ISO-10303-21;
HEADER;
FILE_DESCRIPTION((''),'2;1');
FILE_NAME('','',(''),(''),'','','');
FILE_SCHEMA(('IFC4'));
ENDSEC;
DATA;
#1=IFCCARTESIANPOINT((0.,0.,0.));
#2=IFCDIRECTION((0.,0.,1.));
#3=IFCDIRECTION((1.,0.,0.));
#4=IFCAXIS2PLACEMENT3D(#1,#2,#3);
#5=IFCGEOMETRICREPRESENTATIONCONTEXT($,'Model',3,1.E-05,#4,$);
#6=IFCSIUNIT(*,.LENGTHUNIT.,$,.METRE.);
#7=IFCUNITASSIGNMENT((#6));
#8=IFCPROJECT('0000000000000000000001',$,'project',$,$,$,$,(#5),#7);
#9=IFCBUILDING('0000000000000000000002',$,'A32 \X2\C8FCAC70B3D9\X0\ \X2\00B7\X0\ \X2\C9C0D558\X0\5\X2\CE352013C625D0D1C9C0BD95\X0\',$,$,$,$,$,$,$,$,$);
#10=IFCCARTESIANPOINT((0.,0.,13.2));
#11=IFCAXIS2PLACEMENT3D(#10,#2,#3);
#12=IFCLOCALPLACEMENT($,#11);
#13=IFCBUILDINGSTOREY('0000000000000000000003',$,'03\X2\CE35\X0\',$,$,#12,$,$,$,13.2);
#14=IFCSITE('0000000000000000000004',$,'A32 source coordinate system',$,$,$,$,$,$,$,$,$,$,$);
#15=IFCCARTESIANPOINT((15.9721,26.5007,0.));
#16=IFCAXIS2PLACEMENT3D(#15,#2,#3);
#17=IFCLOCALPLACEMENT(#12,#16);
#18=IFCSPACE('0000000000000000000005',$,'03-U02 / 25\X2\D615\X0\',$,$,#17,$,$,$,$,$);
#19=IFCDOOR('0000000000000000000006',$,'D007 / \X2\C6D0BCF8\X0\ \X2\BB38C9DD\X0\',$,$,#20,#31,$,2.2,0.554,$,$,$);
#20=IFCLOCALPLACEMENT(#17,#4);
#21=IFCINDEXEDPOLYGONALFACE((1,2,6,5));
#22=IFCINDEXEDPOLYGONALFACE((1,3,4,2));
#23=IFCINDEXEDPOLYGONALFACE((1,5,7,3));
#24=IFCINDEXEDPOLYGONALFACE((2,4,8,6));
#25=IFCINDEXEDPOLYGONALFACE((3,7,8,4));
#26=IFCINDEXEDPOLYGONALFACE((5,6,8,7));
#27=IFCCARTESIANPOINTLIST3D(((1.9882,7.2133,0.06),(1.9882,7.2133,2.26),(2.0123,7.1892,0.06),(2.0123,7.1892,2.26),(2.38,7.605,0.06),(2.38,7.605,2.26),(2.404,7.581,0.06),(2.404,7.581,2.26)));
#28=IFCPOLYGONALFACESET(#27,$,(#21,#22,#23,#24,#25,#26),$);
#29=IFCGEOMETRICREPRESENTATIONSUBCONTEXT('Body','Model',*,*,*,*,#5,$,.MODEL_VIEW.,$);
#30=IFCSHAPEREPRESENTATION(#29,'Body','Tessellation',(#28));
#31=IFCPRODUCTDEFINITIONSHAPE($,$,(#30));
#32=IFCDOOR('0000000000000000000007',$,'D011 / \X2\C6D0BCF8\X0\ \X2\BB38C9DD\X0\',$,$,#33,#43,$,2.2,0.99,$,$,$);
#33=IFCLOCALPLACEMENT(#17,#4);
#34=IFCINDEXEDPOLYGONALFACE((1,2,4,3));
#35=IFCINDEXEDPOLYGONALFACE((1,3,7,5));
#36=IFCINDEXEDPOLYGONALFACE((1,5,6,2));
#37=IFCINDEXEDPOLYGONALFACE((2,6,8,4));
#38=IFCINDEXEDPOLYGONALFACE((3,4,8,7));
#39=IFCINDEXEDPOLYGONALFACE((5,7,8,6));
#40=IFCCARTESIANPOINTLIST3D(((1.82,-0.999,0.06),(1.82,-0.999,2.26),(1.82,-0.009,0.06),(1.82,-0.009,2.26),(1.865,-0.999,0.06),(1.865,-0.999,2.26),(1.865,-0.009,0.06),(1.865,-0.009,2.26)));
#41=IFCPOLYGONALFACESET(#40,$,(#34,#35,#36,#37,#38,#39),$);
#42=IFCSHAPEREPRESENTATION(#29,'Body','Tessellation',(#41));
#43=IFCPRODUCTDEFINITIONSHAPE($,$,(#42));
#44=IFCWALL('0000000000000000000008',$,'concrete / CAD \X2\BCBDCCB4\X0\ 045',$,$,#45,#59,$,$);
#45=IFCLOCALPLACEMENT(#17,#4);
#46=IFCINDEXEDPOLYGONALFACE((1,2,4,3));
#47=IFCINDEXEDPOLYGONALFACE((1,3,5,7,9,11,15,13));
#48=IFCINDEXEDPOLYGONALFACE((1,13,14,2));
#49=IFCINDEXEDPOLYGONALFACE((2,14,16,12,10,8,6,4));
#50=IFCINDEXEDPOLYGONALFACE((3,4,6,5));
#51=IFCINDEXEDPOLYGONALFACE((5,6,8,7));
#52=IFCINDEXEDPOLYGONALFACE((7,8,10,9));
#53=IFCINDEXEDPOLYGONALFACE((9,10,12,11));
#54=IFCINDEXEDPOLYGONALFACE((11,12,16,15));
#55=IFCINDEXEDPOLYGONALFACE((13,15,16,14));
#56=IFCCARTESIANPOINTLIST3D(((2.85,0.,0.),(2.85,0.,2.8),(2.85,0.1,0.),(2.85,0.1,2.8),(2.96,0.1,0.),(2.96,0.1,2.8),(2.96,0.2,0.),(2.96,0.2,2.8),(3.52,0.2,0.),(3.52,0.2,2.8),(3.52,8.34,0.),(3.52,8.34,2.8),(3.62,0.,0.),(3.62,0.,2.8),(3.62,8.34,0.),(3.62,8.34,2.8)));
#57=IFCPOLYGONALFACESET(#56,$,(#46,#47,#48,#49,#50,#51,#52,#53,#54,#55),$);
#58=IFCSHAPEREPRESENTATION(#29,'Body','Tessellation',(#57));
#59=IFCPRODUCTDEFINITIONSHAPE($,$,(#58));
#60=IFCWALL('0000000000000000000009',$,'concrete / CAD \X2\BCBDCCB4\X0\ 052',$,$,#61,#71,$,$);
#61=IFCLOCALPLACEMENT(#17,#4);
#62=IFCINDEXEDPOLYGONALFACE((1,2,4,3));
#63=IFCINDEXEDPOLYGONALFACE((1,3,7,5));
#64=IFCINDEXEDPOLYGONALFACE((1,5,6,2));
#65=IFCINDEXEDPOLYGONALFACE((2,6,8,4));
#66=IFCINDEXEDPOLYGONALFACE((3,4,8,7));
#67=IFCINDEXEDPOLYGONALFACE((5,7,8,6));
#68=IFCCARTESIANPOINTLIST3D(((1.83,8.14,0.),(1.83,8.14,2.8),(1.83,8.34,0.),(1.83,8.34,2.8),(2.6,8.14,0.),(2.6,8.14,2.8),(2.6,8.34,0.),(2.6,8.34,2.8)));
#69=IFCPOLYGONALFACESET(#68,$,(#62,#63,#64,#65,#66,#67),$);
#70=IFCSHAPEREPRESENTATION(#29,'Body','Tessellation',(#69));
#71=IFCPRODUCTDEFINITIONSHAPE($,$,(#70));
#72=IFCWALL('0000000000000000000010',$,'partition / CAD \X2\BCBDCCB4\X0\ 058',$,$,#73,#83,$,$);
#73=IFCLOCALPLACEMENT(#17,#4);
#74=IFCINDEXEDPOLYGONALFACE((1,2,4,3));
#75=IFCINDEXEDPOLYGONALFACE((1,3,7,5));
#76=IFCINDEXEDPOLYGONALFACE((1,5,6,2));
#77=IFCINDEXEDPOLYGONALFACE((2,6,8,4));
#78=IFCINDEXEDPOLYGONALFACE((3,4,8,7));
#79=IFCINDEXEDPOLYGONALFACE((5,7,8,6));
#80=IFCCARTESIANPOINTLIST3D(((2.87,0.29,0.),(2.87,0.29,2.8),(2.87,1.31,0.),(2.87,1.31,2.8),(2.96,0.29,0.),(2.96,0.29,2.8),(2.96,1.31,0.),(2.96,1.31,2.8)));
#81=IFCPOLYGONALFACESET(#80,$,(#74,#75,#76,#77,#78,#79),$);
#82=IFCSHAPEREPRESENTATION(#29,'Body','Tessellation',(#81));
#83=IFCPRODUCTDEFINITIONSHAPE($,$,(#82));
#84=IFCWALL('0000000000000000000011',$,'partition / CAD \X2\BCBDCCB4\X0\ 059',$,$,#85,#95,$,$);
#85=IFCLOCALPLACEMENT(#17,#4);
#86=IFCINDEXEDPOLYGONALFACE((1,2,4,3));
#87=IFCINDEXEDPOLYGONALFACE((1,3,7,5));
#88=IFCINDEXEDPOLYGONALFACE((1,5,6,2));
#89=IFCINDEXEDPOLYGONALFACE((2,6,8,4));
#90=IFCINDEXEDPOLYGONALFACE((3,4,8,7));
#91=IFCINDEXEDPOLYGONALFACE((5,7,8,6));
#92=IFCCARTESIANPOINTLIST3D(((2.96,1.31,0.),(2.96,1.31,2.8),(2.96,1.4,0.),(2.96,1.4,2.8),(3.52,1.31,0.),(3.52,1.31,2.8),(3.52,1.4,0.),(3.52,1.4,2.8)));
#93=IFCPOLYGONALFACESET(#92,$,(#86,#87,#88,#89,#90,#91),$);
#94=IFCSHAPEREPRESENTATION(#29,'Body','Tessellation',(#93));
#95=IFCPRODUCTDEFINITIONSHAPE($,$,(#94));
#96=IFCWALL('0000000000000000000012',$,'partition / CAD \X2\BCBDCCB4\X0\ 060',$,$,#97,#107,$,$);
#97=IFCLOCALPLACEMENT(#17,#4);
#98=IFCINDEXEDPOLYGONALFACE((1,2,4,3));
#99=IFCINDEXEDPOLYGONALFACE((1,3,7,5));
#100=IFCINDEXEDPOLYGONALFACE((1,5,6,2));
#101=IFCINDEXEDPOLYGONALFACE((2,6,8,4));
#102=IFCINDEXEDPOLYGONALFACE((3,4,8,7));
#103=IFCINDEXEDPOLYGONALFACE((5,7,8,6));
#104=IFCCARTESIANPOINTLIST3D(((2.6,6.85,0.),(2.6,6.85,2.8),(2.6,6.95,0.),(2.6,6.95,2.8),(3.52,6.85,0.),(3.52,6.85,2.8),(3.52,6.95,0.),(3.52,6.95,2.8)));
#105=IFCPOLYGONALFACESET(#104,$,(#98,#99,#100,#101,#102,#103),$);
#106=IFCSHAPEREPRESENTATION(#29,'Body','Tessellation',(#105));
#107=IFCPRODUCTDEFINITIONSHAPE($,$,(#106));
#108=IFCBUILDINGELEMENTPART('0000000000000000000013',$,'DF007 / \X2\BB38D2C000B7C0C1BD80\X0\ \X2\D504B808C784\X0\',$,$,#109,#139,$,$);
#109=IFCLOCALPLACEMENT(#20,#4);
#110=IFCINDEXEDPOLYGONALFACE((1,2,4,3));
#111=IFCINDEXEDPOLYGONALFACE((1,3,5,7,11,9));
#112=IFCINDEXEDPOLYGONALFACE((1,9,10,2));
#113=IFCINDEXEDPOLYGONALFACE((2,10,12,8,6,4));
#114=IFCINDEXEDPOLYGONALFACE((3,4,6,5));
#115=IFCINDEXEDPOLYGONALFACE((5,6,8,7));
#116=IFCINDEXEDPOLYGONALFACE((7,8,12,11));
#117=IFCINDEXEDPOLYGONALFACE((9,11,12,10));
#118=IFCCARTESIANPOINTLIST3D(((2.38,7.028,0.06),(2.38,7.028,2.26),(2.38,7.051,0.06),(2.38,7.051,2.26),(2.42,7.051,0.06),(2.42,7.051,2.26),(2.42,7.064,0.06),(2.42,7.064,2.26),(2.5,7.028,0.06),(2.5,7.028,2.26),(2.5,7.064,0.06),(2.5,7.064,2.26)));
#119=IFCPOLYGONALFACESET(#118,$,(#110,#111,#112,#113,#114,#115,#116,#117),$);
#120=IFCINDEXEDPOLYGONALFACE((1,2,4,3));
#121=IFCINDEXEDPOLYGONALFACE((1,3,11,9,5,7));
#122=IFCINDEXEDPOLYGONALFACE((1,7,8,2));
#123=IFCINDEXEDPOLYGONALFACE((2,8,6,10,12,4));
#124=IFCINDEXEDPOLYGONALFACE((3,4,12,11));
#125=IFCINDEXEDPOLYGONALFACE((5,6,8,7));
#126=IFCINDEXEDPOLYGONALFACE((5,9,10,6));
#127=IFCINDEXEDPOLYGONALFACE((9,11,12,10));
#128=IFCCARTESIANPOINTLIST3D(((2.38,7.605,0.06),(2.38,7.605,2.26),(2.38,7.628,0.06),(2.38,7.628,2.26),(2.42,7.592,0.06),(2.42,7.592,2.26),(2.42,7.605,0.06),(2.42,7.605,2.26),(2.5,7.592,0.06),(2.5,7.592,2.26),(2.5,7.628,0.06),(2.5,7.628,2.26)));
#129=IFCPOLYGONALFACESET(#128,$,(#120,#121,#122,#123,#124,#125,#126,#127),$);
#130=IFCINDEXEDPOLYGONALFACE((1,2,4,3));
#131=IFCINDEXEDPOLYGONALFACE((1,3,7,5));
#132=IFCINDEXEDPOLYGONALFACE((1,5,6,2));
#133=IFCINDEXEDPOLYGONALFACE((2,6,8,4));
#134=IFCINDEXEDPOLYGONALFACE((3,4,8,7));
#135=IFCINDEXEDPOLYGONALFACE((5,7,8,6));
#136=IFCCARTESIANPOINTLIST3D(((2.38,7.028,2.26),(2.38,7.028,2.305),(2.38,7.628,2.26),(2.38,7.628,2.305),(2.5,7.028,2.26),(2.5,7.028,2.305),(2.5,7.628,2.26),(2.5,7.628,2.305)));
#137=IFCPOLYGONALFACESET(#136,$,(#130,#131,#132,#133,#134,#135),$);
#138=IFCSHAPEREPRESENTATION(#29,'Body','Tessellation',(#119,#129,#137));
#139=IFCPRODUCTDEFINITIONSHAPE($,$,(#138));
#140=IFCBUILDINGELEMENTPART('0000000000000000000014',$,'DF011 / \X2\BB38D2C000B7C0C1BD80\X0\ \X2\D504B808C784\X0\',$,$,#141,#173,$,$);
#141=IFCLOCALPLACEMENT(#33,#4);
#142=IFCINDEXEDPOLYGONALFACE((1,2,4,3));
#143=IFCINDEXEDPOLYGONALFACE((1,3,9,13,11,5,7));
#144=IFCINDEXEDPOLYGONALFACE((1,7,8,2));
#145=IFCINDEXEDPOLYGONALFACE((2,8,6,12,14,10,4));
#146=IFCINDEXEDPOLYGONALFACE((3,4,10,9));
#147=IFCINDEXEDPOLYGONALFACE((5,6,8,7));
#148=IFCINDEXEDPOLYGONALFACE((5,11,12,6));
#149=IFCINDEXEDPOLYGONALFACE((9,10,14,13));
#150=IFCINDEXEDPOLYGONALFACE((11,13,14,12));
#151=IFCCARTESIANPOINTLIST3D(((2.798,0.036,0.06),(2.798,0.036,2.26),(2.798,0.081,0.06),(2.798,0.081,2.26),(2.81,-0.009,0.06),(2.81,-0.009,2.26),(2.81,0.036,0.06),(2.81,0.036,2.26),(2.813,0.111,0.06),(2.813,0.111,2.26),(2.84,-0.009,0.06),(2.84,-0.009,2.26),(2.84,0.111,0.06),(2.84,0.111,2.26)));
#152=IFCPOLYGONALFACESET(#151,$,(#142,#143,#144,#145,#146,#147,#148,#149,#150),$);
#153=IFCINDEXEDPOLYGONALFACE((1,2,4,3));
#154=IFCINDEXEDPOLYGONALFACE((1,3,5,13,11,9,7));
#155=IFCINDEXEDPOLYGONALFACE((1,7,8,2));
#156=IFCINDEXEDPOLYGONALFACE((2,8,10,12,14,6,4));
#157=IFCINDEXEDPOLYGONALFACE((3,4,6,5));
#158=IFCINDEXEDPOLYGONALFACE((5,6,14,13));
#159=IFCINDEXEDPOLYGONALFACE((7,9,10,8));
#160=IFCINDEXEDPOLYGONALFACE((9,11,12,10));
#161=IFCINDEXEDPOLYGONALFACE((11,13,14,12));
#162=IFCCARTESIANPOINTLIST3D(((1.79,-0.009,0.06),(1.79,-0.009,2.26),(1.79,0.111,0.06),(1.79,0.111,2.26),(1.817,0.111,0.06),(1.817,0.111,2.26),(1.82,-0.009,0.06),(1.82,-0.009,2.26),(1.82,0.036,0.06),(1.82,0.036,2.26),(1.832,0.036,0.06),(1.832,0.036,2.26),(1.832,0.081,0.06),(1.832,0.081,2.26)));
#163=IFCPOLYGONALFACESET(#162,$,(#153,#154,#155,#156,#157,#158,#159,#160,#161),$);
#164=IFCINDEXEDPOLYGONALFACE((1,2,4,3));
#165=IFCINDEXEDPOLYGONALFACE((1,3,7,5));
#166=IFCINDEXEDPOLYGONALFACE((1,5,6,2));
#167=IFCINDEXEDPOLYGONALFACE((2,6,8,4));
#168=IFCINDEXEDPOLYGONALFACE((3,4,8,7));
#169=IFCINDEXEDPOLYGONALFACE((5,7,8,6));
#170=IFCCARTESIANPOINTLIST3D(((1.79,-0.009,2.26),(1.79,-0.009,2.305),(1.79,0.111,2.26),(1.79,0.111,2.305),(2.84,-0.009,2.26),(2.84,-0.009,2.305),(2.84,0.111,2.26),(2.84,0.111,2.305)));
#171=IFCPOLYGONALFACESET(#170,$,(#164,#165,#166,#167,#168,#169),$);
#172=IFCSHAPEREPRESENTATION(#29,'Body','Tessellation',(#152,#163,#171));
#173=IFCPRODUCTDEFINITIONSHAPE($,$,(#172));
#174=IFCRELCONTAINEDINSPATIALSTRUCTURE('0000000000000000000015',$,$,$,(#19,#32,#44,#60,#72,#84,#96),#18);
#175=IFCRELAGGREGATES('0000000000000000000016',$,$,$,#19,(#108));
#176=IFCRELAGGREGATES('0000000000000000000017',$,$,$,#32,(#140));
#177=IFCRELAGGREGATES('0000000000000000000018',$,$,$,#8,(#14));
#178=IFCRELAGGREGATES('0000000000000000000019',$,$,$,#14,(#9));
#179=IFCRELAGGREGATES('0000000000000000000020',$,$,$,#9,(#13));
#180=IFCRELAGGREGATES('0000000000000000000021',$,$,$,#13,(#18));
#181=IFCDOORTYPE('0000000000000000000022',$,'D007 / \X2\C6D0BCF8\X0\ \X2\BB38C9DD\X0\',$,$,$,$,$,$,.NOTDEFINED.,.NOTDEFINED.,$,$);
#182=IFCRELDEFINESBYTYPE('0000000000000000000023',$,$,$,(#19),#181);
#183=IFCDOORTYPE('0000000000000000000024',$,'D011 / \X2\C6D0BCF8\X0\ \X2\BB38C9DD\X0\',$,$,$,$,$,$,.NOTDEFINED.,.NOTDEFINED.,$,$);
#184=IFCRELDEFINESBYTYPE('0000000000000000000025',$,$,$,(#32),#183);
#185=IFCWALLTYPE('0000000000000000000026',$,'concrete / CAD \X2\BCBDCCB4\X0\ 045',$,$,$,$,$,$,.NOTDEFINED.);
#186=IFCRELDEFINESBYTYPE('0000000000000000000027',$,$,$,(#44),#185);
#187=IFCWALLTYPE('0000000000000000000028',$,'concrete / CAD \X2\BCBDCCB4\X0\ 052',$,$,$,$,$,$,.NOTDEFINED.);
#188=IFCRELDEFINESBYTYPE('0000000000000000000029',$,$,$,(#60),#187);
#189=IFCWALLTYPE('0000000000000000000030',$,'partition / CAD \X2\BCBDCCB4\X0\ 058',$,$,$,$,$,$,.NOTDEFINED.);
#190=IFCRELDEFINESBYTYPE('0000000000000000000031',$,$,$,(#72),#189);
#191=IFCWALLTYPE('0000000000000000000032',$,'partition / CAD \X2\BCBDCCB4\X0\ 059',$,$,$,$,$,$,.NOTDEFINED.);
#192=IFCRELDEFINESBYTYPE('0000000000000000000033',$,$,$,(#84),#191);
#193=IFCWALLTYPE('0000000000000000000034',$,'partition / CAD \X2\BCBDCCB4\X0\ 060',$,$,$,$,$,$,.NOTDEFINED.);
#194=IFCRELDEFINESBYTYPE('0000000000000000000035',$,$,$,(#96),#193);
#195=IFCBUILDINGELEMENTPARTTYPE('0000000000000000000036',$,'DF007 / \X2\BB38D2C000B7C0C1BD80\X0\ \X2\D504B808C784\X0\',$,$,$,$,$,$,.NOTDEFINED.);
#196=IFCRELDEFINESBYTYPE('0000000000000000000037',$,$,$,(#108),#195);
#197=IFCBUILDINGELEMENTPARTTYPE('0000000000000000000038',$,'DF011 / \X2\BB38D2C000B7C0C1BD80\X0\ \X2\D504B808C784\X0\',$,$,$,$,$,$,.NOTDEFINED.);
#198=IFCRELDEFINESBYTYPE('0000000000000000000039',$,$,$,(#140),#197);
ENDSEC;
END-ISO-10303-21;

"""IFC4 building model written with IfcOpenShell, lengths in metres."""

from ifc_helpers import new_model, si_unit, frame, origin, origin_with_axes, place, context, subcontext, project, spatial, polyline, outline, extrude, source, transform, mapped, type_object, type_shapes, element, aggregate, save


model = new_model("IFC4")

# Units and contexts
model_context = context("Model", 3, precision=1e-05, world=origin_with_axes())
body_context = subcontext(model_context, "Body", "Model", "MODEL_VIEW")
ifc_project = project(units=[si_unit("LENGTHUNIT", "METRE")], contexts=[model_context])

# Site, building, storey, space
storey_placement = place(None, frame((0.0, 0.0, 13.2), z_axis=(0.0, 0.0, 1.0), x_axis=(1.0, 0.0, 0.0)))
space_placement = place(storey_placement, frame((15.9721, 26.5007, 0.0), z_axis=(0.0, 0.0, 1.0), x_axis=(1.0, 0.0, 0.0)))
site = spatial("IfcSite", under=ifc_project, Name="A32 source coordinate system")
building = spatial("IfcBuilding", under=site, Name="A32 주거동 · 지하5층–옥탑지붕")
storey = spatial("IfcBuildingStorey", under=building, at=storey_placement, Name="03층", Elevation=13.2)
space = spatial("IfcSpace", under=storey, at=space_placement, Name="03-U02 / 25형")

# Doors
door_type_1 = type_object("IfcDoorType", Name="D007 / 원본 문짝", OperationType="NOTDEFINED", PredefinedType="NOTDEFINED")
shared_shape_1 = source(origin(), body_context, "Body", "SweptSolid", [
    extrude(outline(polyline([(2.0123, 7.1892), (1.9882, 7.2133), (2.38, 7.605), (2.404, 7.581), (2.0123, 7.1892)])), frame((0.0, 0.0, 0.06)), (0.0, 0.0, 1.0), 2.2),
])
type_shapes(door_type_1, [shared_shape_1])
door_1_placement = place(space_placement, origin_with_axes())
door_1 = element("IfcDoor", 1, at=door_1_placement, inside=space, type_object=door_type_1, Name="D007 / 원본 문짝", OverallHeight=2.2, OverallWidth=0.554, context=body_context, shape_type="MappedRepresentation", body=[
    mapped(shared_shape_1, transform((0.0, 0.0, 0.0), scale=1.0)),
])
door_type_2 = type_object("IfcDoorType", Name="D011 / 원본 문짝", OperationType="NOTDEFINED", PredefinedType="NOTDEFINED")
shared_shape_2 = source(origin(), body_context, "Body", "SweptSolid", [
    extrude(outline(polyline([(1.865, -0.999), (1.82, -0.999), (1.82, -0.009), (1.865, -0.009), (1.865, -0.999)])), frame((0.0, 0.0, 0.06)), (0.0, 0.0, 1.0), 2.2),
])
type_shapes(door_type_2, [shared_shape_2])
door_2_placement = place(space_placement, origin_with_axes())
door_2 = element("IfcDoor", 2, at=door_2_placement, inside=space, type_object=door_type_2, Name="D011 / 원본 문짝", OverallHeight=2.2, OverallWidth=0.99, context=body_context, shape_type="MappedRepresentation", body=[
    mapped(shared_shape_2, transform((0.0, 0.0, 0.0), scale=1.0)),
])

# Walls
wall_type_1 = type_object("IfcWallType", Name="concrete / CAD 벽체 045", PredefinedType="NOTDEFINED")
shared_shape_3 = source(origin(), body_context, "Body", "SweptSolid", [
    extrude(outline(polyline([(2.96, 0.1), (2.96, 0.2), (3.52, 0.2), (3.52, 8.34), (3.72, 8.34), (3.72, 8.34), (3.62, 8.34), (3.62, 0.0), (2.85, 0.0), (2.85, 0.1), (2.96, 0.1)])), origin(), (0.0, 0.0, 1.0), 2.8),
])
type_shapes(wall_type_1, [shared_shape_3])
wall_1_placement = place(space_placement, origin_with_axes())
element("IfcWall", 3, at=wall_1_placement, inside=space, type_object=wall_type_1, Name="concrete / CAD 벽체 045", context=body_context, shape_type="MappedRepresentation", body=[
    mapped(shared_shape_3, transform((0.0, 0.0, 0.0), scale=1.0)),
])
wall_type_2 = type_object("IfcWallType", Name="concrete / CAD 벽체 052", PredefinedType="NOTDEFINED")
shared_shape_4 = source(origin(), body_context, "Body", "SweptSolid", [
    extrude(outline(polyline([(2.6, 8.14), (1.83, 8.14), (1.83, 8.34), (2.6, 8.34), (2.6, 8.14)])), origin(), (0.0, 0.0, 1.0), 2.8),
])
type_shapes(wall_type_2, [shared_shape_4])
wall_2_placement = place(space_placement, origin_with_axes())
element("IfcWall", 4, at=wall_2_placement, inside=space, type_object=wall_type_2, Name="concrete / CAD 벽체 052", context=body_context, shape_type="MappedRepresentation", body=[
    mapped(shared_shape_4, transform((0.0, 0.0, 0.0), scale=1.0)),
])
wall_type_3 = type_object("IfcWallType", Name="partition / CAD 벽체 058", PredefinedType="NOTDEFINED")
shared_shape_5 = source(origin(), body_context, "Body", "SweptSolid", [
    extrude(outline(polyline([(2.96, 1.31), (2.96, 0.29), (2.87, 0.29), (2.87, 1.31), (2.96, 1.31)])), origin(), (0.0, 0.0, 1.0), 2.8),
])
type_shapes(wall_type_3, [shared_shape_5])
wall_3_placement = place(space_placement, origin_with_axes())
element("IfcWall", 5, at=wall_3_placement, inside=space, type_object=wall_type_3, Name="partition / CAD 벽체 058", context=body_context, shape_type="MappedRepresentation", body=[
    mapped(shared_shape_5, transform((0.0, 0.0, 0.0), scale=1.0)),
])
wall_type_4 = type_object("IfcWallType", Name="partition / CAD 벽체 059", PredefinedType="NOTDEFINED")
shared_shape_6 = source(origin(), body_context, "Body", "SweptSolid", [
    extrude(outline(polyline([(3.52, 1.31), (2.96, 1.31), (2.96, 1.4), (3.52, 1.4), (3.52, 1.31)])), origin(), (0.0, 0.0, 1.0), 2.8),
])
type_shapes(wall_type_4, [shared_shape_6])
wall_4_placement = place(space_placement, origin_with_axes())
element("IfcWall", 6, at=wall_4_placement, inside=space, type_object=wall_type_4, Name="partition / CAD 벽체 059", context=body_context, shape_type="MappedRepresentation", body=[
    mapped(shared_shape_6, transform((0.0, 0.0, 0.0), scale=1.0)),
])
wall_type_5 = type_object("IfcWallType", Name="partition / CAD 벽체 060", PredefinedType="NOTDEFINED")
shared_shape_7 = source(origin(), body_context, "Body", "SweptSolid", [
    extrude(outline(polyline([(3.52, 6.85), (2.6, 6.85), (2.6, 6.95), (3.52, 6.95), (3.52, 6.85)])), origin(), (0.0, 0.0, 1.0), 2.8),
])
type_shapes(wall_type_5, [shared_shape_7])
wall_5_placement = place(space_placement, origin_with_axes())
element("IfcWall", 7, at=wall_5_placement, inside=space, type_object=wall_type_5, Name="partition / CAD 벽체 060", context=body_context, shape_type="MappedRepresentation", body=[
    mapped(shared_shape_7, transform((0.0, 0.0, 0.0), scale=1.0)),
])

# Building element parts
building_element_part_type_1 = type_object("IfcBuildingElementPartType", Name="DF007 / 문틀·상부 프레임", PredefinedType="NOTDEFINED")
shared_shape_8 = source(origin(), body_context, "Body", "SweptSolid", [
    extrude(outline(polyline([(2.38, 7.028), (2.38, 7.051), (2.42, 7.051), (2.42, 7.064), (2.5, 7.064), (2.5, 7.028), (2.38, 7.028)])), frame((0.0, 0.0, 0.06)), (0.0, 0.0, 1.0), 2.2),
    extrude(outline(polyline([(2.5, 7.592), (2.42, 7.592), (2.42, 7.605), (2.38, 7.605), (2.38, 7.628), (2.5, 7.628), (2.5, 7.592)])), frame((0.0, 0.0, 0.06)), (0.0, 0.0, 1.0), 2.2),
    extrude(outline(polyline([(2.38, 7.028), (2.38, 7.628), (2.5, 7.628), (2.5, 7.028), (2.38, 7.028)])), frame((0.0, 0.0, 2.26)), (0.0, 0.0, 1.0), 0.045),
])
type_shapes(building_element_part_type_1, [shared_shape_8])
building_element_part_1_placement = place(door_1_placement, origin_with_axes())
building_element_part_1 = element("IfcBuildingElementPart", 8, at=building_element_part_1_placement, type_object=building_element_part_type_1, Name="DF007 / 문틀·상부 프레임", context=body_context, shape_type="MappedRepresentation", body=[
    mapped(shared_shape_8, transform((0.0, 0.0, 0.0), scale=1.0)),
])
aggregate(door_1, [building_element_part_1])
building_element_part_type_2 = type_object("IfcBuildingElementPartType", Name="DF011 / 문틀·상부 프레임", PredefinedType="NOTDEFINED")
shared_shape_9 = source(origin(), body_context, "Body", "SweptSolid", [
    extrude(outline(polyline([(2.81, -0.009), (2.81, 0.036), (2.798, 0.036), (2.798, 0.081), (2.813, 0.111), (2.84, 0.111), (2.84, -0.009), (2.81, -0.009)])), frame((0.0, 0.0, 0.06)), (0.0, 0.0, 1.0), 2.2),
    extrude(outline(polyline([(1.79, 0.111), (1.817, 0.111), (1.832, 0.081), (1.832, 0.036), (1.82, 0.036), (1.82, -0.009), (1.79, -0.009), (1.79, 0.111)])), frame((0.0, 0.0, 0.06)), (0.0, 0.0, 1.0), 2.2),
    extrude(outline(polyline([(1.79, -0.009), (1.79, 0.111), (2.84, 0.111), (2.84, -0.009), (1.79, -0.009)])), frame((0.0, 0.0, 2.26)), (0.0, 0.0, 1.0), 0.045),
])
type_shapes(building_element_part_type_2, [shared_shape_9])
building_element_part_2_placement = place(door_2_placement, origin_with_axes())
building_element_part_2 = element("IfcBuildingElementPart", 9, at=building_element_part_2_placement, type_object=building_element_part_type_2, Name="DF011 / 문틀·상부 프레임", context=body_context, shape_type="MappedRepresentation", body=[
    mapped(shared_shape_9, transform((0.0, 0.0, 0.0), scale=1.0)),
])
aggregate(door_2, [building_element_part_2])

save(model, "model.ifc")
